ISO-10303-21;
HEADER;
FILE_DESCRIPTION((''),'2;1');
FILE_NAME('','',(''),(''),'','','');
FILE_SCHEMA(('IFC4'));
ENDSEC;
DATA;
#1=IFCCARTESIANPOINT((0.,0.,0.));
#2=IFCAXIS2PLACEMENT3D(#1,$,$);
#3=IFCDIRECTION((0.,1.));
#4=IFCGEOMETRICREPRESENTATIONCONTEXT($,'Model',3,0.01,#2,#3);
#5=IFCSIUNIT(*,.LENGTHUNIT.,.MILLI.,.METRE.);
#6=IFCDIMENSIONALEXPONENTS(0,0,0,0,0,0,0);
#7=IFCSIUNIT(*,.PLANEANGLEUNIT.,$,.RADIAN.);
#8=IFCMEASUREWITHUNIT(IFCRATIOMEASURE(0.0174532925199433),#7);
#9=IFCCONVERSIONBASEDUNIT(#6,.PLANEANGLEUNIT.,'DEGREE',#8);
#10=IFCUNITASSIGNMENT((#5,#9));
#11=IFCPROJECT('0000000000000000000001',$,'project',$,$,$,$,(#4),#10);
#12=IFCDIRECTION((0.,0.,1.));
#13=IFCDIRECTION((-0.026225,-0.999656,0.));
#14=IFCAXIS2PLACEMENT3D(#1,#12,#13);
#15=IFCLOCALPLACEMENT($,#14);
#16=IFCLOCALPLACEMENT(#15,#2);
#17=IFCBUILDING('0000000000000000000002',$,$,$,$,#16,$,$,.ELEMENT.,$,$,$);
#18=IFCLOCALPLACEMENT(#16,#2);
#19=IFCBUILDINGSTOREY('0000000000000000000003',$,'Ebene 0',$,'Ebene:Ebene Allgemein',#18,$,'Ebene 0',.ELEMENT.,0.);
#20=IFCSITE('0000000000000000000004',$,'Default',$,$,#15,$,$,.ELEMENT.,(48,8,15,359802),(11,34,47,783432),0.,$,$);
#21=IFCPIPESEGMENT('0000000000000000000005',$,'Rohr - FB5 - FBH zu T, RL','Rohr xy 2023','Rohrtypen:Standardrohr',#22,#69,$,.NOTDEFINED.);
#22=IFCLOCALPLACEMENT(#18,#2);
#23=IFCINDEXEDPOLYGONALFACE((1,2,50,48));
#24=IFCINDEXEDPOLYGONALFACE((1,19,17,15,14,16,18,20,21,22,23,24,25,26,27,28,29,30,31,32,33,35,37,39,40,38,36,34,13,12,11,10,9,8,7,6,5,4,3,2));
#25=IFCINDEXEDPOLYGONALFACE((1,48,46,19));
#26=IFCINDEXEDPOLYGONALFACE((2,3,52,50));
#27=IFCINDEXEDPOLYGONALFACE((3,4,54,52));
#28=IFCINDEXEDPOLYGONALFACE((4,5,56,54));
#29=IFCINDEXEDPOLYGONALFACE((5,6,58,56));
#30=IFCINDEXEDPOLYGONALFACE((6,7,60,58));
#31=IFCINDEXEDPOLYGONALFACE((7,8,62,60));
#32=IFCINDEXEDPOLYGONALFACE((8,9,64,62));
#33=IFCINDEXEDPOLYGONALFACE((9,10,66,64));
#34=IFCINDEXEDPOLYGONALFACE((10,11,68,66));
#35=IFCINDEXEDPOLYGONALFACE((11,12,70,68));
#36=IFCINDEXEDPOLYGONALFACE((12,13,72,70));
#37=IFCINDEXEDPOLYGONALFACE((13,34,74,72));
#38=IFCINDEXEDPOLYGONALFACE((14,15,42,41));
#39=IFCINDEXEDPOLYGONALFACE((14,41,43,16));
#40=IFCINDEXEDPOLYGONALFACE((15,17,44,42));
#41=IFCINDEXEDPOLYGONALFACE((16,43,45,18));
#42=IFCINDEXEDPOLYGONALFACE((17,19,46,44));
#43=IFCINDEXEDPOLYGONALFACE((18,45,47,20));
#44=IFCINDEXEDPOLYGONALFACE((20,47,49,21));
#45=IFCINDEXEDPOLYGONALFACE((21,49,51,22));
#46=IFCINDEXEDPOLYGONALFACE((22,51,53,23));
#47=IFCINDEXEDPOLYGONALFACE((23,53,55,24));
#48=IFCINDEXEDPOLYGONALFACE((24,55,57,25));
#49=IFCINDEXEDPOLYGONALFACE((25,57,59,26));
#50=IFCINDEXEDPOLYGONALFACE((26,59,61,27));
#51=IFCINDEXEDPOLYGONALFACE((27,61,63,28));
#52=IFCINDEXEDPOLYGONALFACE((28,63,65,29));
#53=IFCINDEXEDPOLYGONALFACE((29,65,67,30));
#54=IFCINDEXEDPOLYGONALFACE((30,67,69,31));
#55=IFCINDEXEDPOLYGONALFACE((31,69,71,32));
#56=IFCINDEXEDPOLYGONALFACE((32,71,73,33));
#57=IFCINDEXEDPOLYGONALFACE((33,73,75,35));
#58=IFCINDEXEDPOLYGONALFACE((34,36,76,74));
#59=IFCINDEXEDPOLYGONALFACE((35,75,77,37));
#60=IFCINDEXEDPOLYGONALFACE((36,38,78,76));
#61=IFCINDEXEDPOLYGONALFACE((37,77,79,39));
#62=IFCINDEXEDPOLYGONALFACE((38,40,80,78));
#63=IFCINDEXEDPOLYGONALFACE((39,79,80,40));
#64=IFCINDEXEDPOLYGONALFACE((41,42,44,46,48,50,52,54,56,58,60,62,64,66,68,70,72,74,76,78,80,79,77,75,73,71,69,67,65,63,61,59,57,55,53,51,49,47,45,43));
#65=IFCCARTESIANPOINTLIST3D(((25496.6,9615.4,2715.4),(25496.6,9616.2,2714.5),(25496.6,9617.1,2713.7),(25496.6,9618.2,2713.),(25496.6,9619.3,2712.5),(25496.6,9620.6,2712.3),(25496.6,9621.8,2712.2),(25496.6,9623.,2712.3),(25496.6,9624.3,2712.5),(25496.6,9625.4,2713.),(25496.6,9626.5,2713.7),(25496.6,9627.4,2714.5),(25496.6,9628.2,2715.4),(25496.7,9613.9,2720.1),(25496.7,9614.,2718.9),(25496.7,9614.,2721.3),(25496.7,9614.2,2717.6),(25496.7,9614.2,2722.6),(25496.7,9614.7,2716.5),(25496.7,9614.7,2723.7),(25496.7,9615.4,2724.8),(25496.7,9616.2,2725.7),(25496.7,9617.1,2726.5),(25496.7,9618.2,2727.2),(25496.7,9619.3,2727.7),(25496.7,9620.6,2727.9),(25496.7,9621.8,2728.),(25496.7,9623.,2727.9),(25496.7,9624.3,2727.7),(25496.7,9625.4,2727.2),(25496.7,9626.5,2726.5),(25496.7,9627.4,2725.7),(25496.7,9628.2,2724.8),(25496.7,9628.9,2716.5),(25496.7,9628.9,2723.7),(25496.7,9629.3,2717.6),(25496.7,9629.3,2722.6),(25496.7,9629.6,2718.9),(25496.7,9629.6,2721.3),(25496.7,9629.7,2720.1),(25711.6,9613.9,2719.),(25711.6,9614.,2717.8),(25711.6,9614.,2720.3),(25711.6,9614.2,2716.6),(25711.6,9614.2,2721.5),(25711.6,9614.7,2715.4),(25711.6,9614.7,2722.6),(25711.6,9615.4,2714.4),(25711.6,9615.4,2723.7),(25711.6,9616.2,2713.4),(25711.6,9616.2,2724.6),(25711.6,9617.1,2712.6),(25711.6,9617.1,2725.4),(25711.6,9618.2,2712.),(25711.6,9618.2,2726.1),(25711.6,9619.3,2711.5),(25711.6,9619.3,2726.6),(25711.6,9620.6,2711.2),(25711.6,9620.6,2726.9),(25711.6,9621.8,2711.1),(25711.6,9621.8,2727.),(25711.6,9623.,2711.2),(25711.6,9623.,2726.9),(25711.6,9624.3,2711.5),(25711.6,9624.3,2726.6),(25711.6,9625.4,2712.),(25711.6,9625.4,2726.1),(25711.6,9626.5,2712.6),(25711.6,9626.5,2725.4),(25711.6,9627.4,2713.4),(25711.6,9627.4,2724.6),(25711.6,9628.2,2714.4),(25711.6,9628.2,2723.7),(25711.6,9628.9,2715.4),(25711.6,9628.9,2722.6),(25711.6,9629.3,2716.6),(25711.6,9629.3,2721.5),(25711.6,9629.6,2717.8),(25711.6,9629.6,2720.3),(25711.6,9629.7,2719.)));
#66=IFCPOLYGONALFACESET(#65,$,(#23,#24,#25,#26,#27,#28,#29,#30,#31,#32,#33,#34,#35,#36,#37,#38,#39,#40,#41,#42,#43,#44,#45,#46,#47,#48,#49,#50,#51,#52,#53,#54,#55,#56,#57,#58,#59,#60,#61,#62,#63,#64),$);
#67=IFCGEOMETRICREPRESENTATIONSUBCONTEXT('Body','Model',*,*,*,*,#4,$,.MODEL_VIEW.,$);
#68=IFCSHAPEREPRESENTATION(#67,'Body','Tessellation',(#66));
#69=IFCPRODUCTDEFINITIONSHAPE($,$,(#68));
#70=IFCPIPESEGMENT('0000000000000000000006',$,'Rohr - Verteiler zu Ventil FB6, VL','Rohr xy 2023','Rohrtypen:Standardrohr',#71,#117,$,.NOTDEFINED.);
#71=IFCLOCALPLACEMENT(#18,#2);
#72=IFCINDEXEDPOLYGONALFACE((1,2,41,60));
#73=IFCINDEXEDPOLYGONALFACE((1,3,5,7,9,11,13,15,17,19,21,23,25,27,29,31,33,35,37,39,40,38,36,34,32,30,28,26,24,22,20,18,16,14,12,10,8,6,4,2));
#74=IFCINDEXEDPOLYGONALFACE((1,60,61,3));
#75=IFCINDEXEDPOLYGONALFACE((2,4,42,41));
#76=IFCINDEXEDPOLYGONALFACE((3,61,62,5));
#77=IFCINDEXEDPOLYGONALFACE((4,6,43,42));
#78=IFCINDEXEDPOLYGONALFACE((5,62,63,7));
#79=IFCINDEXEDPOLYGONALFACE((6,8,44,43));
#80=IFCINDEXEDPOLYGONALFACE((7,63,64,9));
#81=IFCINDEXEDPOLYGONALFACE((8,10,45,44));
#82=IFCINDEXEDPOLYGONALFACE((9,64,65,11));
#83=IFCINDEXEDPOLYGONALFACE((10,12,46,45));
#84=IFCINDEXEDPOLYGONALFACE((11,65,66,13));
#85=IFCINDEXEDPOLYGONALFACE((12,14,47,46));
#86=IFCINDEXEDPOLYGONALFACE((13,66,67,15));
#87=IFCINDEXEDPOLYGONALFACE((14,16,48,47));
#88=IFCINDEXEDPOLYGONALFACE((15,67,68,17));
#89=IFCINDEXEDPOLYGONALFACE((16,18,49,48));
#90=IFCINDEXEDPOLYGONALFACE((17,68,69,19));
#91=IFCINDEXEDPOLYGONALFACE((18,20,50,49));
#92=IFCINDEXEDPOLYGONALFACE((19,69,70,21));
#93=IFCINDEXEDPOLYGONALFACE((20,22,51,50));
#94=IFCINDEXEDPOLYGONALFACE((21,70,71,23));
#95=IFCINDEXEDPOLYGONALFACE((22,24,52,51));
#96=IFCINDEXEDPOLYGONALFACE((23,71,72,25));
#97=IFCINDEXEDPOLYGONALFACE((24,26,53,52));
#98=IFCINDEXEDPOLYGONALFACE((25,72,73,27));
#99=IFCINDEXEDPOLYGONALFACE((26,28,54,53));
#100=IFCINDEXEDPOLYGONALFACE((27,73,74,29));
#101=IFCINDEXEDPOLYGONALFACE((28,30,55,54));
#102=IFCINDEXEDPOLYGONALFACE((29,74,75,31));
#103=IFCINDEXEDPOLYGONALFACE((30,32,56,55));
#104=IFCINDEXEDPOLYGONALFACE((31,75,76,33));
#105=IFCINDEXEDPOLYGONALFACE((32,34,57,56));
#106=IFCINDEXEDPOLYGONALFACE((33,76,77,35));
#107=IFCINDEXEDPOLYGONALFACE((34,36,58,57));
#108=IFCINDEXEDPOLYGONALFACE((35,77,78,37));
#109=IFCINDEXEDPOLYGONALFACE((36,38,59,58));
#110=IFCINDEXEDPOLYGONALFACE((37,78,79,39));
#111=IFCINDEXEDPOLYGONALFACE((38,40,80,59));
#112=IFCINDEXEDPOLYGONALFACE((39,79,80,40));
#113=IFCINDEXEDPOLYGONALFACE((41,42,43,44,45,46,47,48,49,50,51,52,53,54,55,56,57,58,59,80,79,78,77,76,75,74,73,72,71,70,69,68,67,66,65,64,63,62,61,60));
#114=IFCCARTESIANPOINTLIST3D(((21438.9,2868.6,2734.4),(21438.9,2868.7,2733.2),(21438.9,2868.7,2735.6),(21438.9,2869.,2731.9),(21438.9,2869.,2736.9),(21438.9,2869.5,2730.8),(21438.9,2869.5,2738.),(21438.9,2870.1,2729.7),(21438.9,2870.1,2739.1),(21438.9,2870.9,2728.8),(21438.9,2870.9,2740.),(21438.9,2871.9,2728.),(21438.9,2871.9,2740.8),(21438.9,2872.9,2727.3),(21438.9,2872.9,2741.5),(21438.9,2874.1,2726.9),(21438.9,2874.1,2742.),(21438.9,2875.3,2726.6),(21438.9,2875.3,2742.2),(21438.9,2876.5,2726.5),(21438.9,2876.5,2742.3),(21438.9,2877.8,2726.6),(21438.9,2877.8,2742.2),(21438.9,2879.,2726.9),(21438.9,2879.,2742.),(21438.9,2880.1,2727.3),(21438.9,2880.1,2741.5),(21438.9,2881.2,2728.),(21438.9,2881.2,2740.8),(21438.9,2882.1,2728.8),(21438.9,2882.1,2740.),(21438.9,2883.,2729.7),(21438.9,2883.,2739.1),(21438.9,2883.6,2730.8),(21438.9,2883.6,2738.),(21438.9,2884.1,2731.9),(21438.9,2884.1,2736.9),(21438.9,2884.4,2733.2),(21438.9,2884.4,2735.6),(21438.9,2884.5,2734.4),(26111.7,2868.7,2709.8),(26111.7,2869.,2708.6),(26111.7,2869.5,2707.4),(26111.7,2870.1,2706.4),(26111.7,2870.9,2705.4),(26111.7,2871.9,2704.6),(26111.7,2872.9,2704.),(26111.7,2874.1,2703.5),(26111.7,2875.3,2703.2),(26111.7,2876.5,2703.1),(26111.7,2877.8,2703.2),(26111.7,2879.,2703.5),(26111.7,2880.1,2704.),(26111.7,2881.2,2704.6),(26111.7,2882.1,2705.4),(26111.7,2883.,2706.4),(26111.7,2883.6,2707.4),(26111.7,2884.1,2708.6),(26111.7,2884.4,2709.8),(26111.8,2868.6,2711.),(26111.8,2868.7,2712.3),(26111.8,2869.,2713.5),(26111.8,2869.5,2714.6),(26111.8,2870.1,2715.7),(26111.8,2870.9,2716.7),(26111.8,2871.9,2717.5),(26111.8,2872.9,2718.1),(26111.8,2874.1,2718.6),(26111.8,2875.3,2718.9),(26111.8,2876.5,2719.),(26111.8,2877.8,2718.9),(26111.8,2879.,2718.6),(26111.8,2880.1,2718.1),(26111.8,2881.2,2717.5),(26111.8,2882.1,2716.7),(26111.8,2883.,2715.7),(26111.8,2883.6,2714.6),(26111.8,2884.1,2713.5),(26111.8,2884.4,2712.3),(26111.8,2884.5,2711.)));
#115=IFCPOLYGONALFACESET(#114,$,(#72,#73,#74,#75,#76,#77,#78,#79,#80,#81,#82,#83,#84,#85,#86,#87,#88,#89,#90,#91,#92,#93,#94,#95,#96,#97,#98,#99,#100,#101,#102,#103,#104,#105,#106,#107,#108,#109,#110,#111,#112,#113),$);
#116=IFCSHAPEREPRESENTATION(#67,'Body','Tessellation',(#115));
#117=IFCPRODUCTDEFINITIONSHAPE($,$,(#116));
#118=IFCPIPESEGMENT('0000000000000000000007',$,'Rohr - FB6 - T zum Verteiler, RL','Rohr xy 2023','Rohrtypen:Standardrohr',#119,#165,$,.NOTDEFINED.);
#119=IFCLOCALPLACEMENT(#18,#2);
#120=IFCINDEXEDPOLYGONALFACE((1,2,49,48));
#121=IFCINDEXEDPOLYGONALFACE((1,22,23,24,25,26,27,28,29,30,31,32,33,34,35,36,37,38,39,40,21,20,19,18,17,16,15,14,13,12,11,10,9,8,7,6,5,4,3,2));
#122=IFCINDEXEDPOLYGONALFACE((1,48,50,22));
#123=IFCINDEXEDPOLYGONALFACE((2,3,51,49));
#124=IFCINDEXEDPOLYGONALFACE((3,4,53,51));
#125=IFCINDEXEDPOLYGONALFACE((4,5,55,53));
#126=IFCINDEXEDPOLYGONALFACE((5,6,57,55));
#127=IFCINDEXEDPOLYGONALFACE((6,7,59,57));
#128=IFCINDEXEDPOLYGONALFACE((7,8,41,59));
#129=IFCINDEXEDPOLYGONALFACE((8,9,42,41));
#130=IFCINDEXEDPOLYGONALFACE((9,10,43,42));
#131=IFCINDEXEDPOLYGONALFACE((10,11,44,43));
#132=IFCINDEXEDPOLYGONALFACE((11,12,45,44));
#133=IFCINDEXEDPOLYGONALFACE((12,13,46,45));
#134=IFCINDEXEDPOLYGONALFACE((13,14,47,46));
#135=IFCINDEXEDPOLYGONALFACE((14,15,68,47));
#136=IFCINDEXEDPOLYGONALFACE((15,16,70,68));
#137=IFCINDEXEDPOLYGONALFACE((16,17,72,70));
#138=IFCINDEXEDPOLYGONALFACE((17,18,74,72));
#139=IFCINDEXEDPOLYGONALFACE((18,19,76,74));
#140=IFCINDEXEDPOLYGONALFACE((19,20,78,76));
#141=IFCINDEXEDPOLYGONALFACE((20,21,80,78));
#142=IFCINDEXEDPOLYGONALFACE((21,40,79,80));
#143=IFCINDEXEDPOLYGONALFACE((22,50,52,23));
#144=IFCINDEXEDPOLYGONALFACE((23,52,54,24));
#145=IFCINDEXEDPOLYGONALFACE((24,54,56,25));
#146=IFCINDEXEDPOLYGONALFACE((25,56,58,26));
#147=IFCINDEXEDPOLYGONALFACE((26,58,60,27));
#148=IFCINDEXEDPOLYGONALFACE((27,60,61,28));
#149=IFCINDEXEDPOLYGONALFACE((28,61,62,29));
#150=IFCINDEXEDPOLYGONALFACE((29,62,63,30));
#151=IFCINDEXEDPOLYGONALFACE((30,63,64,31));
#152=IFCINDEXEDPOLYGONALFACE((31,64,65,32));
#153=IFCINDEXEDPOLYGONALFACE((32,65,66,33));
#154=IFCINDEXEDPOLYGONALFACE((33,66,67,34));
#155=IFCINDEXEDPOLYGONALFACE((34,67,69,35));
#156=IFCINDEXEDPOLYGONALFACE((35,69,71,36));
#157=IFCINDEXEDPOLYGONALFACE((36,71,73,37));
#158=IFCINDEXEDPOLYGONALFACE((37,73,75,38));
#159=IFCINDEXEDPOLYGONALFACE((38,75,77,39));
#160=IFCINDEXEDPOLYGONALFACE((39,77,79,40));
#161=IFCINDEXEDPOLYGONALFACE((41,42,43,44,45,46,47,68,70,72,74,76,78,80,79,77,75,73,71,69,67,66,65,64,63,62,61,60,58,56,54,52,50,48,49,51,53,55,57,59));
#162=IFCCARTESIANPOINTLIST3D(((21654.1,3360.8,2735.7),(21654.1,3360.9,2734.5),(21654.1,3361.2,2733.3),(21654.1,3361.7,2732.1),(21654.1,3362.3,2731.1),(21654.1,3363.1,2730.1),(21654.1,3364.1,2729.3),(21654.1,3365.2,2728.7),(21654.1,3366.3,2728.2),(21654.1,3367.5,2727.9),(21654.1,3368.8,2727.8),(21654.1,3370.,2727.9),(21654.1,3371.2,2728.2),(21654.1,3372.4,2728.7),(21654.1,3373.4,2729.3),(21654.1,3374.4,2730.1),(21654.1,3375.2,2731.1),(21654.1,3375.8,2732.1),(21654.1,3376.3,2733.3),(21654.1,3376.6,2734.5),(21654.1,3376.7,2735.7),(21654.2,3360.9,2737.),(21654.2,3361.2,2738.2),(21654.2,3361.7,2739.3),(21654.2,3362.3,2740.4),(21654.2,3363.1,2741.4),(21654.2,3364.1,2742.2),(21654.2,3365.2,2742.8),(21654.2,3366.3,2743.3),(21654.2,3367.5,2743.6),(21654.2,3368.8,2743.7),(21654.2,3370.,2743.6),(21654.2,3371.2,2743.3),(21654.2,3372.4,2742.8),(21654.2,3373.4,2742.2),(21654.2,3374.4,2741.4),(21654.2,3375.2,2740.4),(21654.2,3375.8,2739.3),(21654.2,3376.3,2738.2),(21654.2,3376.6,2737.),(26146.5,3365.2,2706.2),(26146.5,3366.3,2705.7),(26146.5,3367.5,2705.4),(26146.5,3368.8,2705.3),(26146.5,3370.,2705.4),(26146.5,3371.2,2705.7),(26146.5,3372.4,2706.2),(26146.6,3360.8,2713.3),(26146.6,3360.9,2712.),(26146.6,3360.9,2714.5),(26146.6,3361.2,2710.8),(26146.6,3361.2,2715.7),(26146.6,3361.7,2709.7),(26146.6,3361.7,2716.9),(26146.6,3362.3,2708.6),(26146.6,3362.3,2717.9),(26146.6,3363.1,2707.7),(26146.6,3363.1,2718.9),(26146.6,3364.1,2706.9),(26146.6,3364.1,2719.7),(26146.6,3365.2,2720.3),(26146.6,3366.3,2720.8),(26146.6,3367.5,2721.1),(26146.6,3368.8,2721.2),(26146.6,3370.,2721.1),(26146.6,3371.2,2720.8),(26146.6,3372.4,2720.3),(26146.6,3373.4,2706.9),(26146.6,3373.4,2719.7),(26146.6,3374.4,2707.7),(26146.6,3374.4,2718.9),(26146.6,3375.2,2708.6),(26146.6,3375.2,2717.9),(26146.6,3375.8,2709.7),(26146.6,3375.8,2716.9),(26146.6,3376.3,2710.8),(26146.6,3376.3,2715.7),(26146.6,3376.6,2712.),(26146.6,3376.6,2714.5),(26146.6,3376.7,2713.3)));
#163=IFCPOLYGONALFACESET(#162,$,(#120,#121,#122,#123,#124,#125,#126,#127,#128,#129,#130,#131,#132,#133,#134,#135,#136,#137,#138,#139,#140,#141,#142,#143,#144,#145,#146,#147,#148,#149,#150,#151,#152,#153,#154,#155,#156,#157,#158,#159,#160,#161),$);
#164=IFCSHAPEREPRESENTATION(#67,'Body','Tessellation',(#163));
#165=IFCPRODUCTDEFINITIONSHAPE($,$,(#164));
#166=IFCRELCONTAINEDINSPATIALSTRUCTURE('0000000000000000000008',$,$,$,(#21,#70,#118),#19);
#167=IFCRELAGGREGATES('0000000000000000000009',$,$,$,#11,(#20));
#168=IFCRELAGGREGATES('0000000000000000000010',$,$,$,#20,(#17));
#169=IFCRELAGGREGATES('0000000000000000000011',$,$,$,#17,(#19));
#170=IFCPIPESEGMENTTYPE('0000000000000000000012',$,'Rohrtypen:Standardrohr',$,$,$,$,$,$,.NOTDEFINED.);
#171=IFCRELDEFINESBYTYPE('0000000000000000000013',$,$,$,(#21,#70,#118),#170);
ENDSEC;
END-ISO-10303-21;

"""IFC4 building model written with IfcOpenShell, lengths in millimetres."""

from ifc_helpers import new_model, entity, si_unit, converted_unit, direction, frame, origin, place, context, subcontext, project, spatial, indexed_curve, outline, extrude, type_object, element, save


model = new_model("IFC4")

# Units and contexts
model_context = context("Model", 3, precision=0.01, world=origin(), true_north=direction((0.0, 1.0)))
body_context = subcontext(model_context, "Body", "Model", "MODEL_VIEW")
ifc_project = project(units=[si_unit("LENGTHUNIT", "METRE", prefix="MILLI"), converted_unit("PLANEANGLEUNIT", "DEGREE", entity("IfcRatioMeasure", 0.0174532925199433), si_unit("PLANEANGLEUNIT", "RADIAN"), dimensions=[0, 0, 0, 0, 0, 0, 0])], contexts=[model_context])

# Site, building, storey
site_placement = place(None, frame((0.0, 0.0, 0.0), z_axis=(0.0, 0.0, 1.0), x_axis=(-0.026225, -0.999656, 0.0)))
site = spatial("IfcSite", under=ifc_project, at=site_placement, Name="Default", CompositionType="ELEMENT", RefLatitude=(48, 8, 15, 359802), RefLongitude=(11, 34, 47, 783432), RefElevation=0.0)
building_placement = place(site_placement, origin())
building = spatial("IfcBuilding", under=site, at=building_placement, CompositionType="ELEMENT")
storey_placement = place(building_placement, origin())
storey = spatial("IfcBuildingStorey", under=building, at=storey_placement, Name="Ebene 0", ObjectType="Ebene:Ebene Allgemein", LongName="Ebene 0", CompositionType="ELEMENT", Elevation=0.0)

# Pipe segments
pipe_segment_type = type_object("IfcPipeSegmentType", Name="Rohrtypen:Standardrohr", PredefinedType="NOTDEFINED")
pipe_segment_1_placement = place(storey_placement, origin())
element("IfcPipeSegment", 1, at=pipe_segment_1_placement, inside=storey, type_object=pipe_segment_type, Name="Rohr - FB5 - FBH zu T, RL", Description="Rohr xy 2023", ObjectType="Rohrtypen:Standardrohr", PredefinedType="NOTDEFINED", context=body_context, shape_type="SweptSolid", body=[
    extrude(outline(indexed_curve([(7.9, 0.0), (7.8, 1.2), (7.6, 2.5), (7.1, 3.6), (6.4, 4.7), (5.6, 5.6), (4.7, 6.4), (3.6, 7.1), (2.5, 7.6), (1.2, 7.8), (0.0, 7.9), (-1.2, 7.8), (-2.5, 7.6), (-3.6, 7.1), (-4.7, 6.4), (-5.6, 5.6), (-6.4, 4.7), (-7.1, 3.6), (-7.6, 2.5), (-7.8, 1.2), (-7.9, 0.0), (-7.8, -1.2), (-7.6, -2.5), (-7.1, -3.6), (-6.4, -4.7), (-5.6, -5.6), (-4.7, -6.4), (-3.6, -7.1), (-2.5, -7.6), (-1.2, -7.8), (0.0, -7.9), (1.2, -7.8), (2.5, -7.6), (3.6, -7.1), (4.7, -6.4), (5.6, -5.6), (6.4, -4.7), (7.1, -3.6), (7.6, -2.5), (7.8, -1.2), (7.9, 0.0)], self_intersect=False)), frame((25711.6, 9621.8, 2719.0), z_axis=(-0.999988, 0.0, 0.005), x_axis=(0.0, 1.0, 0.0)), (0.0, 0.0, 1.0), 214.9),
])
pipe_segment_2_placement = place(storey_placement, origin())
element("IfcPipeSegment", 2, at=pipe_segment_2_placement, inside=storey, type_object=pipe_segment_type, Name="Rohr - Verteiler zu Ventil FB6, VL", Description="Rohr xy 2023", ObjectType="Rohrtypen:Standardrohr", PredefinedType="NOTDEFINED", context=body_context, shape_type="SweptSolid", body=[
    extrude(outline(indexed_curve([(7.9, 0.0), (7.8, 1.2), (7.6, 2.5), (7.1, 3.6), (6.4, 4.7), (5.6, 5.6), (4.7, 6.4), (3.6, 7.1), (2.5, 7.6), (1.2, 7.8), (0.0, 7.9), (-1.2, 7.8), (-2.5, 7.6), (-3.6, 7.1), (-4.7, 6.4), (-5.6, 5.6), (-6.4, 4.7), (-7.1, 3.6), (-7.6, 2.5), (-7.8, 1.2), (-7.9, 0.0), (-7.8, -1.2), (-7.6, -2.5), (-7.1, -3.6), (-6.4, -4.7), (-5.6, -5.6), (-4.7, -6.4), (-3.6, -7.1), (-2.5, -7.6), (-1.2, -7.8), (0.0, -7.9), (1.2, -7.8), (2.5, -7.6), (3.6, -7.1), (4.7, -6.4), (5.6, -5.6), (6.4, -4.7), (7.1, -3.6), (7.6, -2.5), (7.8, -1.2), (7.9, 0.0)], self_intersect=False)), frame((26111.8, 2876.5, 2711.0), z_axis=(-0.999988, 0.0, 0.005), x_axis=(0.0, 1.0, 0.0)), (0.0, 0.0, 1.0), 4672.9),
])
pipe_segment_3_placement = place(storey_placement, origin())
element("IfcPipeSegment", 3, at=pipe_segment_3_placement, inside=storey, type_object=pipe_segment_type, Name="Rohr - FB6 - T zum Verteiler, RL", Description="Rohr xy 2023", ObjectType="Rohrtypen:Standardrohr", PredefinedType="NOTDEFINED", context=body_context, shape_type="SweptSolid", body=[
    extrude(outline(indexed_curve([(7.9, 0.0), (7.8, 1.2), (7.6, 2.5), (7.1, 3.6), (6.4, 4.7), (5.6, 5.6), (4.7, 6.4), (3.6, 7.1), (2.5, 7.6), (1.2, 7.8), (0.0, 7.9), (-1.2, 7.8), (-2.5, 7.6), (-3.6, 7.1), (-4.7, 6.4), (-5.6, 5.6), (-6.4, 4.7), (-7.1, 3.6), (-7.6, 2.5), (-7.8, 1.2), (-7.9, 0.0), (-7.8, -1.2), (-7.6, -2.5), (-7.1, -3.6), (-6.4, -4.7), (-5.6, -5.6), (-4.7, -6.4), (-3.6, -7.1), (-2.5, -7.6), (-1.2, -7.8), (0.0, -7.9), (1.2, -7.8), (2.5, -7.6), (3.6, -7.1), (4.7, -6.4), (5.6, -5.6), (6.4, -4.7), (7.1, -3.6), (7.6, -2.5), (7.8, -1.2), (7.9, 0.0)], self_intersect=False)), frame((26146.6, 3368.8, 2713.3), z_axis=(-0.999988, 0.0, 0.005), x_axis=(0.0, 1.0, 0.0)), (0.0, 0.0, 1.0), 4492.5),
])

save(model, "model.ifc")
